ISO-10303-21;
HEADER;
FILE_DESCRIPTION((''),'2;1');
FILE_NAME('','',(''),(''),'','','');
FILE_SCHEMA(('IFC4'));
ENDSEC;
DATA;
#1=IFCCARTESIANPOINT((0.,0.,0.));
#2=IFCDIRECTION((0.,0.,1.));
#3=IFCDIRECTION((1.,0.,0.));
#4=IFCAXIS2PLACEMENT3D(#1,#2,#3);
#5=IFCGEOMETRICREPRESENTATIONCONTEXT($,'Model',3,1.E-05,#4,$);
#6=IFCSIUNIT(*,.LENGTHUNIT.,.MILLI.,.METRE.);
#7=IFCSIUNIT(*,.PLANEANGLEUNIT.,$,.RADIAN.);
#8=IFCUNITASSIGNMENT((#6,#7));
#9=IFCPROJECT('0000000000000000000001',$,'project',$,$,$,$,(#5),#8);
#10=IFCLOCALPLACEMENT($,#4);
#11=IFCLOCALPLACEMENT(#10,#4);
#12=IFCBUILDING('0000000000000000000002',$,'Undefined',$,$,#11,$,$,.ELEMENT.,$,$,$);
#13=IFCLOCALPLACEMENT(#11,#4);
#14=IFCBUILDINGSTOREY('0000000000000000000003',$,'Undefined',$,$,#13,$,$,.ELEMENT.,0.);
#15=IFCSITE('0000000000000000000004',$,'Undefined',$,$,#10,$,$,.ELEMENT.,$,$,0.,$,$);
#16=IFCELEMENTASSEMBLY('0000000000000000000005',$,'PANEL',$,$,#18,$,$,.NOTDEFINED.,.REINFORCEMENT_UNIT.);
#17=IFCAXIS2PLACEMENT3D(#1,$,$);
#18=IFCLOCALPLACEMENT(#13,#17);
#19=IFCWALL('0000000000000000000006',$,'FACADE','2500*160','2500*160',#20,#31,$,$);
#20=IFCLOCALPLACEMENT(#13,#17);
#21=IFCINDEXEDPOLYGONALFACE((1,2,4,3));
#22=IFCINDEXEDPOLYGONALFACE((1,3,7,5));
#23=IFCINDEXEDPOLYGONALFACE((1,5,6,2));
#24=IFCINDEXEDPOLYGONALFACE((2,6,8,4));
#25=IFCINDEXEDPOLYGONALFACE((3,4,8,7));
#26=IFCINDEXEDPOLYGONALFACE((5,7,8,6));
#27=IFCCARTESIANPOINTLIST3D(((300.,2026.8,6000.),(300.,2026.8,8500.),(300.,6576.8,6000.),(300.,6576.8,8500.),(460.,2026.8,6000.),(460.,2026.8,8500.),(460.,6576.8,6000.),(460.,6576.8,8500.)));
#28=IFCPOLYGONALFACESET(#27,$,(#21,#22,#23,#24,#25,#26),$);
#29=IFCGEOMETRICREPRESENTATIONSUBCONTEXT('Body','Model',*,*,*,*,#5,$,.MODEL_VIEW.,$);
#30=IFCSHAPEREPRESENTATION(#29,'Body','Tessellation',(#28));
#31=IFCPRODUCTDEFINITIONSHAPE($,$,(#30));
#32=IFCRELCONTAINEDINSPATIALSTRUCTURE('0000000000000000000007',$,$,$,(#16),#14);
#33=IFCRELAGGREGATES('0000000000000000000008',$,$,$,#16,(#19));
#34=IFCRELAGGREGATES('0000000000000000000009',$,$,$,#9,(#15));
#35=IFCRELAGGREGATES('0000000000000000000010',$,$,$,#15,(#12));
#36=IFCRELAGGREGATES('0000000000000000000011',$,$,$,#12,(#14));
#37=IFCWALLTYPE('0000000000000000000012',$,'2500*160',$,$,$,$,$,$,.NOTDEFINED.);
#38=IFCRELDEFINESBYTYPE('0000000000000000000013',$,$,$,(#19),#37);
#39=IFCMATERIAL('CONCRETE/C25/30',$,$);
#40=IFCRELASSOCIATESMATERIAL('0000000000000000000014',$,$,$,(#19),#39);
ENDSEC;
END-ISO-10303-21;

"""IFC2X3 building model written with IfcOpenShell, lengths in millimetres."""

from ifc_helpers import new_model, si_unit, frame, frame_2d, origin_with_axes, place, context, subcontext, project, spatial, rectangle, extrude, material, type_object, element, aggregate, save


model = new_model("IFC2X3")

# Units and contexts
model_context = context("Model", 3, precision=1e-05, world=origin_with_axes())
body_context = subcontext(model_context, "Body", "Model", "MODEL_VIEW")
ifc_project = project(units=[si_unit("LENGTHUNIT", "METRE", prefix="MILLI"), si_unit("PLANEANGLEUNIT", "RADIAN")], contexts=[model_context])

# Site, building, storey
site_placement = place(None, origin_with_axes())
site = spatial("IfcSite", under=ifc_project, at=site_placement, Name="Undefined", CompositionType="ELEMENT", RefElevation=0.0)
building_placement = place(site_placement, origin_with_axes())
building = spatial("IfcBuilding", under=site, at=building_placement, Name="Undefined", CompositionType="ELEMENT")
storey_placement = place(building_placement, origin_with_axes())
storey = spatial("IfcBuildingStorey", under=building, at=storey_placement, Name="Undefined", CompositionType="ELEMENT", Elevation=0.0)

# Shared definitions
ifc_material_1 = material(Name="CONCRETE/C25/30")

# Element assembly, wall
wall_type = type_object("IfcWallType", Name="2500*160", PredefinedType="NOTDEFINED")
assembly_1_placement = place(storey_placement, origin_with_axes())
assembly_1 = element("IfcElementAssembly", 1, at=assembly_1_placement, inside=storey, Name="PANEL", AssemblyPlace="NOTDEFINED", PredefinedType="REINFORCEMENT_UNIT")
wall_1_placement = place(assembly_1_placement, frame((380.0, 6576.8, 6000.0), z_axis=(0.0, 0.0, 1.0), x_axis=(0.0, -1.0, 0.0)))
wall_1 = element("IfcWall", 2, at=wall_1_placement, type_object=wall_type, material=ifc_material_1, Name="FACADE", Description="2500*160", ObjectType="2500*160", context=body_context, shape_type="SweptSolid", body=[
    extrude(rectangle(XDim=4550.0, YDim=160.0, at=frame_2d((0.0, 2275.0), x_axis=(0.0, -1.0))), frame((0.0, 0.0, 0.0), z_axis=(0.0, 0.0, 1.0), x_axis=(0.0, -1.0, 0.0)), (0.0, 0.0, 1.0), 2500.0),
])
aggregate(assembly_1, [wall_1])

save(model, "model.ifc")
